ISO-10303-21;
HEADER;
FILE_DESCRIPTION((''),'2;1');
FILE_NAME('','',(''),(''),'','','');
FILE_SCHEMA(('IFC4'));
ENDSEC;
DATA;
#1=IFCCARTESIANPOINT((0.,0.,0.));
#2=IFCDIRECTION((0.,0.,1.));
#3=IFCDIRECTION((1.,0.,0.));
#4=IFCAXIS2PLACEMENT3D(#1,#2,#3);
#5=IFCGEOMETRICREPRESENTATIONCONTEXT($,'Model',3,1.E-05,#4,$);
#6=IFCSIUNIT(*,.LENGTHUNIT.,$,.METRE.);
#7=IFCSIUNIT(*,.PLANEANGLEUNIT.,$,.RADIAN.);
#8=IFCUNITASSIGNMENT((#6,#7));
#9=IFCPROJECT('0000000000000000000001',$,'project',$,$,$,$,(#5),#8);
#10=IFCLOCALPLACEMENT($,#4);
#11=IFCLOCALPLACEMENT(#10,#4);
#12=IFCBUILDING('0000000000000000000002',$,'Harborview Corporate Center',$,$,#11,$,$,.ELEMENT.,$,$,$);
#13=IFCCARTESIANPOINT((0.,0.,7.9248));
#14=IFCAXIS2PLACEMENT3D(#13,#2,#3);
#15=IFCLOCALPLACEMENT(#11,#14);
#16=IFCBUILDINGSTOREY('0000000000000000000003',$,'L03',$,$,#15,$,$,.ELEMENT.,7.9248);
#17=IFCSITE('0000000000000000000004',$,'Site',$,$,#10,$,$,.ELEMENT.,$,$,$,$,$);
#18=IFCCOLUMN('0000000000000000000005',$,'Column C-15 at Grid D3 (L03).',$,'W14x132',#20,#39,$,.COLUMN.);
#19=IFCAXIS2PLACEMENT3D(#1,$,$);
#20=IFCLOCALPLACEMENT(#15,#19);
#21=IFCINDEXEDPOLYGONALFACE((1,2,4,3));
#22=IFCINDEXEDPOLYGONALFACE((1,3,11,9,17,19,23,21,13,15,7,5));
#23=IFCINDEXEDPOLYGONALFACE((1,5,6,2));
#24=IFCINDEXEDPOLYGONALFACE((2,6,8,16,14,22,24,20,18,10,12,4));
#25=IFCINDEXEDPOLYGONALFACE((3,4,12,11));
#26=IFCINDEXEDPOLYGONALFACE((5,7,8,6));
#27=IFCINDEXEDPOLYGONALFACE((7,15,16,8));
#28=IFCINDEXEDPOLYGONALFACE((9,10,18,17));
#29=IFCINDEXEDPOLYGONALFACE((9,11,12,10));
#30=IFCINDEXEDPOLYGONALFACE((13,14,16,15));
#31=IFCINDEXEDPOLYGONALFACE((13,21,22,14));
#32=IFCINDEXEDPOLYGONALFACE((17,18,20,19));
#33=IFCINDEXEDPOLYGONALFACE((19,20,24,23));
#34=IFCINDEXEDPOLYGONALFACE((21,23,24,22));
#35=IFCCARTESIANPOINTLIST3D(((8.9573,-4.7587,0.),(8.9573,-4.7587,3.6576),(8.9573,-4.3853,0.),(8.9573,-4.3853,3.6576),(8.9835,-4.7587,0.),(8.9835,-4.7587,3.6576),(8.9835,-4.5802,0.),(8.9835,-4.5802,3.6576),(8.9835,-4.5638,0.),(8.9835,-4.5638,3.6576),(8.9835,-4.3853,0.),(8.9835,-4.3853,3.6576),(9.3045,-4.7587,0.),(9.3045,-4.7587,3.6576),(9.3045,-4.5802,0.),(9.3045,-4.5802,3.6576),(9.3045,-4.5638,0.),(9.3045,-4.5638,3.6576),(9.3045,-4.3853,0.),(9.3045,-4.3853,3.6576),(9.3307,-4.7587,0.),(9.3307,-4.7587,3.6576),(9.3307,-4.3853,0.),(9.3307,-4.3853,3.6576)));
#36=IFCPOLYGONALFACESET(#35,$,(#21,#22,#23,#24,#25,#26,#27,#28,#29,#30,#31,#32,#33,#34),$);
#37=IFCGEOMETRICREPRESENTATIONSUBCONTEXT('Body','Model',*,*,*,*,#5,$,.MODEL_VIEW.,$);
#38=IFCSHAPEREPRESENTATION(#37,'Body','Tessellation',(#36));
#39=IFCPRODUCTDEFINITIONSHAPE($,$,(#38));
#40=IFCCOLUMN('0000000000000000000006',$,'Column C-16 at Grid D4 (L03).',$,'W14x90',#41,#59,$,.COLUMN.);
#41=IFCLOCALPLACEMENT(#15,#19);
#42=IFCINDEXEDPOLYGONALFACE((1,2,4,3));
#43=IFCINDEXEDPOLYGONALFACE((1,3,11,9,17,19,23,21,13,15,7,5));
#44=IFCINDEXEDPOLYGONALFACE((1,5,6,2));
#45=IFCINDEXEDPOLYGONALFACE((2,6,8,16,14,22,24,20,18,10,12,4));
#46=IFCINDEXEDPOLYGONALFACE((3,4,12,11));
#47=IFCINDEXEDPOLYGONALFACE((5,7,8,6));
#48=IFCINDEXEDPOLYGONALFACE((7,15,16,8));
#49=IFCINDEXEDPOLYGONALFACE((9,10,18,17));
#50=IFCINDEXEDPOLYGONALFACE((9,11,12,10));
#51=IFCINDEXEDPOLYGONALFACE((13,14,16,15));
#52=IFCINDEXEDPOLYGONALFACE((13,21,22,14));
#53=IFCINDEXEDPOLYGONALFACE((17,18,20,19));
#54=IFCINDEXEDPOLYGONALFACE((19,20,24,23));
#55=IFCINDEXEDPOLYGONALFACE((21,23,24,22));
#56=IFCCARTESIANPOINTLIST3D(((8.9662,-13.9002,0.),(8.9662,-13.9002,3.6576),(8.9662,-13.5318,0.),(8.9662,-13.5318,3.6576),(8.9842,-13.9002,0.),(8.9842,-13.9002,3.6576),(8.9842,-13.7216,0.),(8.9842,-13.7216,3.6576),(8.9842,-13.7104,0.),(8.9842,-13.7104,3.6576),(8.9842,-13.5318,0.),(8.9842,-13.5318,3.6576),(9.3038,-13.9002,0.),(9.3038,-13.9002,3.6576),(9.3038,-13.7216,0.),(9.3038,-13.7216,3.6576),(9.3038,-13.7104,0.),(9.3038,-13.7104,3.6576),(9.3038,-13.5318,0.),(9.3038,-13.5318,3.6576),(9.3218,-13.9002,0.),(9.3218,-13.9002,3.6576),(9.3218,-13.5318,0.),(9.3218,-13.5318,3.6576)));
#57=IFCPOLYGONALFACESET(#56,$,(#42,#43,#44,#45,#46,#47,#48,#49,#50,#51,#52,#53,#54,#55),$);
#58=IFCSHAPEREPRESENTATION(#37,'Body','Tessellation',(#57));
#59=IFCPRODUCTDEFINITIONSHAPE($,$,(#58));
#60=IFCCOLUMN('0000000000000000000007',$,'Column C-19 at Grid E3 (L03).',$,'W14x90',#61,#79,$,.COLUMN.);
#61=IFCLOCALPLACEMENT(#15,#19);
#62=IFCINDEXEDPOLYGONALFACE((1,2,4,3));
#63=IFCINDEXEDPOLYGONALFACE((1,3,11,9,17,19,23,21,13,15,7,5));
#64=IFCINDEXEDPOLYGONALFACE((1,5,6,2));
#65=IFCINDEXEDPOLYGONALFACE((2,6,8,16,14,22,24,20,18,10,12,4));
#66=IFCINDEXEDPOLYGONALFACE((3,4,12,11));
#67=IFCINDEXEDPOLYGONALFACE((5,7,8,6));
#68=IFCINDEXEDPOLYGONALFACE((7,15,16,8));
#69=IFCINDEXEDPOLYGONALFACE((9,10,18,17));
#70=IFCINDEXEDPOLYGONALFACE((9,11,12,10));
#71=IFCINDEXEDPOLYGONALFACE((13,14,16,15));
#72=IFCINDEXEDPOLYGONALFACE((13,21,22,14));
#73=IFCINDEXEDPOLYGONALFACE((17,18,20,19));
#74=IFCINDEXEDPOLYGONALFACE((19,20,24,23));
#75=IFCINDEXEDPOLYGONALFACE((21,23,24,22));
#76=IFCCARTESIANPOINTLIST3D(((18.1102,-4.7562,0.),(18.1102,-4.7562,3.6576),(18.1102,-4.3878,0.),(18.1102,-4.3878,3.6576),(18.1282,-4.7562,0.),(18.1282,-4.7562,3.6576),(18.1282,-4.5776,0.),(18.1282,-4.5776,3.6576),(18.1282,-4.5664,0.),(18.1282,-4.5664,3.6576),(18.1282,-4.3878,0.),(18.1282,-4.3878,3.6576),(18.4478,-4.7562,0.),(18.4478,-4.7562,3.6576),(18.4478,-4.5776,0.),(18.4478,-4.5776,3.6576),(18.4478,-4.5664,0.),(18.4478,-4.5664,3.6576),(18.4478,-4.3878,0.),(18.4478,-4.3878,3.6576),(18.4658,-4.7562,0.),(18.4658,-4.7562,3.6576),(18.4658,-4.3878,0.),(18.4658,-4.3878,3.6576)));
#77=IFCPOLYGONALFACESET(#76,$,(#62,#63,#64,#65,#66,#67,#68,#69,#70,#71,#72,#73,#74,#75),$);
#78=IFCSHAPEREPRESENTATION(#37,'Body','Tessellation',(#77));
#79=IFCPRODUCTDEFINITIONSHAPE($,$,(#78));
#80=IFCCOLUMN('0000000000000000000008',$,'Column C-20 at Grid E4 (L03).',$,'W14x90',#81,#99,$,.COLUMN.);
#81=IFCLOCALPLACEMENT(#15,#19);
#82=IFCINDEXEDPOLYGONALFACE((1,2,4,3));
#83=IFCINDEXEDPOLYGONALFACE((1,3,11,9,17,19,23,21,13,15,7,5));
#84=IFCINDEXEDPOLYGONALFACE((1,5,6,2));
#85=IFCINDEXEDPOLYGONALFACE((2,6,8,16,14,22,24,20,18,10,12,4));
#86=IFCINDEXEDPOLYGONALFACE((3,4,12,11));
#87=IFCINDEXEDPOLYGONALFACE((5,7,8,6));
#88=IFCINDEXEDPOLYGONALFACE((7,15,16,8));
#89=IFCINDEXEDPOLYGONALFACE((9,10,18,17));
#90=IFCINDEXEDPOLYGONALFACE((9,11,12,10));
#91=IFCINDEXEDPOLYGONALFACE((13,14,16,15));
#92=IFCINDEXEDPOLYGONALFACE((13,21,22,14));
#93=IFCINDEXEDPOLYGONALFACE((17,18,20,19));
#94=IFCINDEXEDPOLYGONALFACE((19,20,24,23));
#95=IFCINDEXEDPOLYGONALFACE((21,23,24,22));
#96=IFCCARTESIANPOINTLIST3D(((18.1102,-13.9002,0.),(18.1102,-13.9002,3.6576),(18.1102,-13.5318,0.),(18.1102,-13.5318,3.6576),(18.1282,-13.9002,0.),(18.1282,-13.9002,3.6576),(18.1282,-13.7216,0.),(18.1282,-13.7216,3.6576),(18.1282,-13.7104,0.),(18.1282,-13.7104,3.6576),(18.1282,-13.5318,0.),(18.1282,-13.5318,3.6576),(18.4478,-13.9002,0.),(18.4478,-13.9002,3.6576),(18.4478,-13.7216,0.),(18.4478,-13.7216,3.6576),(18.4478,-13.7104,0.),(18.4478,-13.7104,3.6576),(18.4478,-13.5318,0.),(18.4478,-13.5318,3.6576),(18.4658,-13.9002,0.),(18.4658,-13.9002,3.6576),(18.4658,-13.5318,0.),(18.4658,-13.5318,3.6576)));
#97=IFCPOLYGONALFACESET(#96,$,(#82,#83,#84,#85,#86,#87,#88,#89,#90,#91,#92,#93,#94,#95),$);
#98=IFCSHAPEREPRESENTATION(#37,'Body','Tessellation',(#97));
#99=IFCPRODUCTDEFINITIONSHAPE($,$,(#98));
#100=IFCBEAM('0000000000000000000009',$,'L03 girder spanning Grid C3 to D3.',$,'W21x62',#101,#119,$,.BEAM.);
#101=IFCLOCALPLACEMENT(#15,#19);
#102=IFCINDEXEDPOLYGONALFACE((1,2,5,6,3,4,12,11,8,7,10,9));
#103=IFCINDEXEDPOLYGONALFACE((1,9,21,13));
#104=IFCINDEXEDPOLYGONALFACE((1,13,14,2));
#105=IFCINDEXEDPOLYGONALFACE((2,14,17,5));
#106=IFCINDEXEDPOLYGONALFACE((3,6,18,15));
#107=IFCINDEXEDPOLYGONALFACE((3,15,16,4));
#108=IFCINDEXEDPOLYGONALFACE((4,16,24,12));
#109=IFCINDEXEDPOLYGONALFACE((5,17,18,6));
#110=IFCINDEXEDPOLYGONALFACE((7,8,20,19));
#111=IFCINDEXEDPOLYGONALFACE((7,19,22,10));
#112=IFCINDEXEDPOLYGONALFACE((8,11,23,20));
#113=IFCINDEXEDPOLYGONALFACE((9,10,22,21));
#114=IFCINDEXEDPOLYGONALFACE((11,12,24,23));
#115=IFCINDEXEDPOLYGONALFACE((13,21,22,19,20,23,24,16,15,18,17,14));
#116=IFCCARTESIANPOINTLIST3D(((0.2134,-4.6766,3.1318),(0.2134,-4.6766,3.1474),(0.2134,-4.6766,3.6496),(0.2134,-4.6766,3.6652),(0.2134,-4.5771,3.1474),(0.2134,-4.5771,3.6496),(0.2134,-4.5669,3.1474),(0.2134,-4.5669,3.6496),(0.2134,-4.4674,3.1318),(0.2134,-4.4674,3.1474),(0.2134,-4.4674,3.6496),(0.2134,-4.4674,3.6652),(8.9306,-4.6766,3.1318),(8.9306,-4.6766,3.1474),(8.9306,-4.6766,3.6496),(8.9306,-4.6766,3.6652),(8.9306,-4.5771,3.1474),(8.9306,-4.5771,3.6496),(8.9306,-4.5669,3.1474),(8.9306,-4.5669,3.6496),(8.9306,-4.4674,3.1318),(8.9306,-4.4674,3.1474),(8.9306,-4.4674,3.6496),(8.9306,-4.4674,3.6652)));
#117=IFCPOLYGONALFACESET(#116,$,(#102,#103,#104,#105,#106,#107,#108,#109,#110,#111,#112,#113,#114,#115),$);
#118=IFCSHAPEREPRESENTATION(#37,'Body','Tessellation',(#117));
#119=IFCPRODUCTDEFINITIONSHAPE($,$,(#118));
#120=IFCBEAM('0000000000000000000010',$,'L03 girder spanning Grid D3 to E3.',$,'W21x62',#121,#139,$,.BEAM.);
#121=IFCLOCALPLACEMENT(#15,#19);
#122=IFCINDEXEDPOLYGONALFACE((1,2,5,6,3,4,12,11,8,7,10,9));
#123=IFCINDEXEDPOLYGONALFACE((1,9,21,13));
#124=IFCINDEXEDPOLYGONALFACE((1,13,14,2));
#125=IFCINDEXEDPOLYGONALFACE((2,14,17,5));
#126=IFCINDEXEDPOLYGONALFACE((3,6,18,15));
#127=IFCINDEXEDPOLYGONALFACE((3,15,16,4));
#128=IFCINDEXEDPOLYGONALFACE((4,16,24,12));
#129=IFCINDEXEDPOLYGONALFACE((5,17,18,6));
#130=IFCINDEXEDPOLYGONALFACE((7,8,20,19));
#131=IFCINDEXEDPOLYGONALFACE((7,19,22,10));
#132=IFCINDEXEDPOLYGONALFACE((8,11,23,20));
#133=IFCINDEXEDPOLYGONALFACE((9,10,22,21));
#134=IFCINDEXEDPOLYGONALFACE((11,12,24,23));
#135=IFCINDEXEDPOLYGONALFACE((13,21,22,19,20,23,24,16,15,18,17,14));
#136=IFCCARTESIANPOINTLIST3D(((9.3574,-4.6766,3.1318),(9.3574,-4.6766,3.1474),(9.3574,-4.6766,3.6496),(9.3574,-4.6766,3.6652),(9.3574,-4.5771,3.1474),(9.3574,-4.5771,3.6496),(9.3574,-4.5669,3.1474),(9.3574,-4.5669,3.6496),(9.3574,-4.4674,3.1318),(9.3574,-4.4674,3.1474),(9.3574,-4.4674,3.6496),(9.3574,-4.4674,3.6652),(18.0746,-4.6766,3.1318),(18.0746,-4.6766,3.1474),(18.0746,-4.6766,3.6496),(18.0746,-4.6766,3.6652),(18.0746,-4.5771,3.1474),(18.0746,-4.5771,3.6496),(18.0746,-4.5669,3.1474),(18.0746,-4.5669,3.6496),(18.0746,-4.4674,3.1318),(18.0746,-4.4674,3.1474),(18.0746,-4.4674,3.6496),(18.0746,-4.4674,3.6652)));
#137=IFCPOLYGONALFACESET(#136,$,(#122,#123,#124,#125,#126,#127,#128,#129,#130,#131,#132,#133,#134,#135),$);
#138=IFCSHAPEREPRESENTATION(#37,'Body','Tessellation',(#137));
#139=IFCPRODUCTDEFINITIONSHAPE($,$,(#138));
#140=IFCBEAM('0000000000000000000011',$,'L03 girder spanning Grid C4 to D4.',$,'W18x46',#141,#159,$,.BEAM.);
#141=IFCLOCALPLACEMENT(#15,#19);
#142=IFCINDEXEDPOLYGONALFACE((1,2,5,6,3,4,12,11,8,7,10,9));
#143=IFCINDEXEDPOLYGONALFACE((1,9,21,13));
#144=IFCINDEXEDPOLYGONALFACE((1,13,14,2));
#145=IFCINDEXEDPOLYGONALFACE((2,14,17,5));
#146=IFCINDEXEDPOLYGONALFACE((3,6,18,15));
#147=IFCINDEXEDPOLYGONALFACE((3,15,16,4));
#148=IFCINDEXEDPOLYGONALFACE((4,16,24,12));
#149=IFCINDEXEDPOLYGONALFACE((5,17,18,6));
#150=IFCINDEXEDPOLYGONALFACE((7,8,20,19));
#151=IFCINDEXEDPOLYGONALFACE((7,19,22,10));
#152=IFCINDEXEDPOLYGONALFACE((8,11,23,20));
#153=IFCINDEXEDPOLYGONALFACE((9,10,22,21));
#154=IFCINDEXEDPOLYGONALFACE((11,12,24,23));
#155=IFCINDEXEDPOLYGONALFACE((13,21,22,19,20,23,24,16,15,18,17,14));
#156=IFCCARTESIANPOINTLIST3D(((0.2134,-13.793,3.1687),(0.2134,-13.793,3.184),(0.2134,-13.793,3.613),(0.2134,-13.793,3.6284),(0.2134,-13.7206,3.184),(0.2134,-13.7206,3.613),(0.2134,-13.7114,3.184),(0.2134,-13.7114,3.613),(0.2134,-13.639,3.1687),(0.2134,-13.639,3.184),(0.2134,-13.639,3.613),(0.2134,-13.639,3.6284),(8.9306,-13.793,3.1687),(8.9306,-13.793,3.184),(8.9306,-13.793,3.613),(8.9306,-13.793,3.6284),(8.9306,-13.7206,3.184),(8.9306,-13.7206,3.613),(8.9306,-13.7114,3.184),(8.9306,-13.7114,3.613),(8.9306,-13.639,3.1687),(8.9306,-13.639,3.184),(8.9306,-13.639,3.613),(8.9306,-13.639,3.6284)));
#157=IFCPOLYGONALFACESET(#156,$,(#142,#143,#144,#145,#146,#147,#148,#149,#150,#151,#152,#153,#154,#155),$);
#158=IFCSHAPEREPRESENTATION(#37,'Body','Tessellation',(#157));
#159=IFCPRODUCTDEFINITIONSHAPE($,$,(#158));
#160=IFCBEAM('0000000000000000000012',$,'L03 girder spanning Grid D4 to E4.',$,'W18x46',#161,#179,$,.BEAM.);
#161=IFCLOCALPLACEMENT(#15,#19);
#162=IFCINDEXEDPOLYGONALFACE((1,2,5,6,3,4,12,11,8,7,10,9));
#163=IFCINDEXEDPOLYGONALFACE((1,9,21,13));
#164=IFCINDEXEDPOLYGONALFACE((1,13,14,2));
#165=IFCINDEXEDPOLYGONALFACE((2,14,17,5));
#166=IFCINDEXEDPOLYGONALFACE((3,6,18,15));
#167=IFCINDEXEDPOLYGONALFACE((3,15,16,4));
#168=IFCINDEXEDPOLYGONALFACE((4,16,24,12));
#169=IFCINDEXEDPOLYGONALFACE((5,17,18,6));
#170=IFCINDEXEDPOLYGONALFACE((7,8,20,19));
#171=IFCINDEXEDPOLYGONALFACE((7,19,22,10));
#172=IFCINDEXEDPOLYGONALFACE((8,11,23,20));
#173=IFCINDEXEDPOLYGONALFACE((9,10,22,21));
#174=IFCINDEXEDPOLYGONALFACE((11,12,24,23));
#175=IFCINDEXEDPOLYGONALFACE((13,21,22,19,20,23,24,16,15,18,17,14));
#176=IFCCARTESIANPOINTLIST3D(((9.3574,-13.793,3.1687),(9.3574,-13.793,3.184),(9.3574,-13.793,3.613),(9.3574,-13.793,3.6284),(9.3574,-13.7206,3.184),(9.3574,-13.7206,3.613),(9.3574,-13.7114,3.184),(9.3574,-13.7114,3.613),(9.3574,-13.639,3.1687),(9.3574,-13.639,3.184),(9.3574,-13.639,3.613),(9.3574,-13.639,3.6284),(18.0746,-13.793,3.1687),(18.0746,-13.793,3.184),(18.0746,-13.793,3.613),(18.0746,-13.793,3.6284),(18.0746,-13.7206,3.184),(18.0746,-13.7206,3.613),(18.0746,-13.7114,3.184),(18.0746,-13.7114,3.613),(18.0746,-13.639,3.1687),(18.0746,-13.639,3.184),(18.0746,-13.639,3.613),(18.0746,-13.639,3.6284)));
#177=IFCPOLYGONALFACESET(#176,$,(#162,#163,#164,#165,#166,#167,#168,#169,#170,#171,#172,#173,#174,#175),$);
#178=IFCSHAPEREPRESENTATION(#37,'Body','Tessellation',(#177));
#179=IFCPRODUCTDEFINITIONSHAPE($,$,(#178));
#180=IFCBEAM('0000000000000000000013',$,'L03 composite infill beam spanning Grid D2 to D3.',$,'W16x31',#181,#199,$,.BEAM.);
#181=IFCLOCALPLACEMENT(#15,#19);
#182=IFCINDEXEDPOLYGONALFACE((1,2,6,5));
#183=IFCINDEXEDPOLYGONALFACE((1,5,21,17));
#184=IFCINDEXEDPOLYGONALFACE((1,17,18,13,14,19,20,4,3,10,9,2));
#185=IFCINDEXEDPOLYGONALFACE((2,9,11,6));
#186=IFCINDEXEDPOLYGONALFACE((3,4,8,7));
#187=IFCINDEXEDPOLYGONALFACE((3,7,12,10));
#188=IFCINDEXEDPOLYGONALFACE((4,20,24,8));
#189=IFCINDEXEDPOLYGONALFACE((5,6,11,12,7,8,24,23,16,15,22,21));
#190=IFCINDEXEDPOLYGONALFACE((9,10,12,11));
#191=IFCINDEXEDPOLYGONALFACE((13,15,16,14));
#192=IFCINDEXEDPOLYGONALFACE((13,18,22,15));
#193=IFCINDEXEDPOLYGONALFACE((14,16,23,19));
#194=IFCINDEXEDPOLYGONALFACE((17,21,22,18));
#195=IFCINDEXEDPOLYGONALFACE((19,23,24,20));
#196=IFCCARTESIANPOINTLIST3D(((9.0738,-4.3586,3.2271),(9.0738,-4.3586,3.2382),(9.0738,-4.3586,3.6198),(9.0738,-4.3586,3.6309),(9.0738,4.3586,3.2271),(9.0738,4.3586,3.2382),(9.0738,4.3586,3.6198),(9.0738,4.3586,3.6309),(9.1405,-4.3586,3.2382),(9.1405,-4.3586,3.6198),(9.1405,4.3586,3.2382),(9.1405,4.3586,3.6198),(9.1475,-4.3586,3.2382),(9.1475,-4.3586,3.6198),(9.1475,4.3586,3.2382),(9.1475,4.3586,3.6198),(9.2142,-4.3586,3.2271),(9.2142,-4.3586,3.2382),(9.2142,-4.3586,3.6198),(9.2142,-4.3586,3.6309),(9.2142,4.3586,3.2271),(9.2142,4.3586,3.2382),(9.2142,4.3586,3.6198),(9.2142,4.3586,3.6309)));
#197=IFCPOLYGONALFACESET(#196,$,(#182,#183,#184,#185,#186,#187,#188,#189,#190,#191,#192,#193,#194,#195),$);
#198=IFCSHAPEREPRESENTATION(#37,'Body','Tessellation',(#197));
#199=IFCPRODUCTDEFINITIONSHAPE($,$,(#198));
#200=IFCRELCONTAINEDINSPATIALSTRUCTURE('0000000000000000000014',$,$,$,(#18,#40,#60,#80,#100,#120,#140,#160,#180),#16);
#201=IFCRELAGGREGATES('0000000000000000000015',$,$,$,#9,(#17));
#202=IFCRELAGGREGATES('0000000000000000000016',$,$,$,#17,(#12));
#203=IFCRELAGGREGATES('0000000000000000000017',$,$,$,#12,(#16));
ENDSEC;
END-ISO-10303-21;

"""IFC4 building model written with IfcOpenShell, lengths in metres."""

from ifc_helpers import new_model, si_unit, frame, origin_with_axes, place, context, subcontext, project, spatial, i_section, extrude, element, save


model = new_model("IFC4")

# Units and contexts
model_context = context("Model", 3, precision=1e-05, world=origin_with_axes())
body_context = subcontext(model_context, "Body", "Model", "MODEL_VIEW")
ifc_project = project(units=[si_unit("LENGTHUNIT", "METRE"), si_unit("PLANEANGLEUNIT", "RADIAN")], contexts=[model_context])

# Site, building, storey
site_placement = place(None, origin_with_axes())
site = spatial("IfcSite", under=ifc_project, at=site_placement, Name="Site", CompositionType="ELEMENT")
building_placement = place(site_placement, origin_with_axes())
building = spatial("IfcBuilding", under=site, at=building_placement, Name="Harborview Corporate Center", CompositionType="ELEMENT")
storey_placement = place(building_placement, frame((0.0, 0.0, 7.9248), z_axis=(0.0, 0.0, 1.0), x_axis=(1.0, 0.0, 0.0)))
storey = spatial("IfcBuildingStorey", under=building, at=storey_placement, Name="L03", CompositionType="ELEMENT", Elevation=7.9248)

# Columns
column_placement = place(storey_placement, frame((9.144, -4.572, 0.0), z_axis=(0.0, 0.0, 1.0), x_axis=(0.0, 1.0, 0.0)))
element("IfcColumn", 1, at=column_placement, inside=storey, Name="Column C-15 at Grid D3 (L03).", ObjectType="W14x132", PredefinedType="COLUMN", context=body_context, shape_type="SweptSolid", body=[
    extrude(i_section(OverallWidth=0.3734, OverallDepth=0.3734, WebThickness=0.0164, FlangeThickness=0.0262), origin_with_axes(), (0.0, 0.0, 1.0), 3.6576),
])
for number, where, z_axis, x_axis, name in (
    (2, (9.144, -13.716, 0.0), (0.0, 0.0, 1.0), (0.0, 1.0, 0.0), "Column C-16 at Grid D4 (L03)."),
    (3, (18.288, -4.572, 0.0), (0.0, 0.0, 1.0), (0.0, 1.0, 0.0), "Column C-19 at Grid E3 (L03)."),
    (4, (18.288, -13.716, 0.0), (0.0, 0.0, 1.0), (0.0, 1.0, 0.0), "Column C-20 at Grid E4 (L03)."),
):
    element("IfcColumn", number, at=place(storey_placement, frame(where, z_axis=z_axis, x_axis=x_axis)), inside=storey, Name=name, ObjectType="W14x90", PredefinedType="COLUMN", context=body_context, shape_type="SweptSolid", body=[
        extrude(i_section(OverallWidth=0.3683, OverallDepth=0.3556, WebThickness=0.0112, FlangeThickness=0.018), origin_with_axes(), (0.0, 0.0, 1.0), 3.6576),
    ])

# Beams
beam_1_placement = place(storey_placement, frame((0.2134, -4.572, 3.3985), z_axis=(1.0, 0.0, 0.0), x_axis=(0.0, 1.0, 0.0)))
element("IfcBeam", 5, at=beam_1_placement, inside=storey, Name="L03 girder spanning Grid C3 to D3.", ObjectType="W21x62", PredefinedType="BEAM", context=body_context, shape_type="SweptSolid", body=[
    extrude(i_section(OverallWidth=0.2093, OverallDepth=0.5334, WebThickness=0.0102, FlangeThickness=0.0156), origin_with_axes(), (0.0, 0.0, 1.0), 8.7173),
])
beam_2_placement = place(storey_placement, frame((9.3574, -4.572, 3.3985), z_axis=(1.0, 0.0, 0.0), x_axis=(0.0, 1.0, 0.0)))
element("IfcBeam", 6, at=beam_2_placement, inside=storey, Name="L03 girder spanning Grid D3 to E3.", ObjectType="W21x62", PredefinedType="BEAM", context=body_context, shape_type="SweptSolid", body=[
    extrude(i_section(OverallWidth=0.2093, OverallDepth=0.5334, WebThickness=0.0102, FlangeThickness=0.0156), origin_with_axes(), (0.0, 0.0, 1.0), 8.7173),
])
beam_3_placement = place(storey_placement, frame((0.2134, -13.716, 3.3985), z_axis=(1.0, 0.0, 0.0), x_axis=(0.0, 1.0, 0.0)))
element("IfcBeam", 7, at=beam_3_placement, inside=storey, Name="L03 girder spanning Grid C4 to D4.", ObjectType="W18x46", PredefinedType="BEAM", context=body_context, shape_type="SweptSolid", body=[
    extrude(i_section(OverallWidth=0.1539, OverallDepth=0.4597, WebThickness=0.0091, FlangeThickness=0.0154), origin_with_axes(), (0.0, 0.0, 1.0), 8.7173),
])
beam_4_placement = place(storey_placement, frame((9.3574, -13.716, 3.3985), z_axis=(1.0, 0.0, 0.0), x_axis=(0.0, 1.0, 0.0)))
element("IfcBeam", 8, at=beam_4_placement, inside=storey, Name="L03 girder spanning Grid D4 to E4.", ObjectType="W18x46", PredefinedType="BEAM", context=body_context, shape_type="SweptSolid", body=[
    extrude(i_section(OverallWidth=0.1539, OverallDepth=0.4597, WebThickness=0.0091, FlangeThickness=0.0154), origin_with_axes(), (0.0, 0.0, 1.0), 8.7173),
])
beam_5_placement = place(storey_placement, frame((9.144, -4.3586, 3.429), z_axis=(0.0, 1.0, 0.0), x_axis=(-1.0, 0.0, 0.0)))
element("IfcBeam", 9, at=beam_5_placement, inside=storey, Name="L03 composite infill beam spanning Grid D2 to D3.", ObjectType="W16x31", PredefinedType="BEAM", context=body_context, shape_type="SweptSolid", body=[
    extrude(i_section(OverallWidth=0.1405, OverallDepth=0.4039, WebThickness=0.007, FlangeThickness=0.0112), origin_with_axes(), (0.0, 0.0, 1.0), 8.7173),
])

save(model, "model.ifc")
